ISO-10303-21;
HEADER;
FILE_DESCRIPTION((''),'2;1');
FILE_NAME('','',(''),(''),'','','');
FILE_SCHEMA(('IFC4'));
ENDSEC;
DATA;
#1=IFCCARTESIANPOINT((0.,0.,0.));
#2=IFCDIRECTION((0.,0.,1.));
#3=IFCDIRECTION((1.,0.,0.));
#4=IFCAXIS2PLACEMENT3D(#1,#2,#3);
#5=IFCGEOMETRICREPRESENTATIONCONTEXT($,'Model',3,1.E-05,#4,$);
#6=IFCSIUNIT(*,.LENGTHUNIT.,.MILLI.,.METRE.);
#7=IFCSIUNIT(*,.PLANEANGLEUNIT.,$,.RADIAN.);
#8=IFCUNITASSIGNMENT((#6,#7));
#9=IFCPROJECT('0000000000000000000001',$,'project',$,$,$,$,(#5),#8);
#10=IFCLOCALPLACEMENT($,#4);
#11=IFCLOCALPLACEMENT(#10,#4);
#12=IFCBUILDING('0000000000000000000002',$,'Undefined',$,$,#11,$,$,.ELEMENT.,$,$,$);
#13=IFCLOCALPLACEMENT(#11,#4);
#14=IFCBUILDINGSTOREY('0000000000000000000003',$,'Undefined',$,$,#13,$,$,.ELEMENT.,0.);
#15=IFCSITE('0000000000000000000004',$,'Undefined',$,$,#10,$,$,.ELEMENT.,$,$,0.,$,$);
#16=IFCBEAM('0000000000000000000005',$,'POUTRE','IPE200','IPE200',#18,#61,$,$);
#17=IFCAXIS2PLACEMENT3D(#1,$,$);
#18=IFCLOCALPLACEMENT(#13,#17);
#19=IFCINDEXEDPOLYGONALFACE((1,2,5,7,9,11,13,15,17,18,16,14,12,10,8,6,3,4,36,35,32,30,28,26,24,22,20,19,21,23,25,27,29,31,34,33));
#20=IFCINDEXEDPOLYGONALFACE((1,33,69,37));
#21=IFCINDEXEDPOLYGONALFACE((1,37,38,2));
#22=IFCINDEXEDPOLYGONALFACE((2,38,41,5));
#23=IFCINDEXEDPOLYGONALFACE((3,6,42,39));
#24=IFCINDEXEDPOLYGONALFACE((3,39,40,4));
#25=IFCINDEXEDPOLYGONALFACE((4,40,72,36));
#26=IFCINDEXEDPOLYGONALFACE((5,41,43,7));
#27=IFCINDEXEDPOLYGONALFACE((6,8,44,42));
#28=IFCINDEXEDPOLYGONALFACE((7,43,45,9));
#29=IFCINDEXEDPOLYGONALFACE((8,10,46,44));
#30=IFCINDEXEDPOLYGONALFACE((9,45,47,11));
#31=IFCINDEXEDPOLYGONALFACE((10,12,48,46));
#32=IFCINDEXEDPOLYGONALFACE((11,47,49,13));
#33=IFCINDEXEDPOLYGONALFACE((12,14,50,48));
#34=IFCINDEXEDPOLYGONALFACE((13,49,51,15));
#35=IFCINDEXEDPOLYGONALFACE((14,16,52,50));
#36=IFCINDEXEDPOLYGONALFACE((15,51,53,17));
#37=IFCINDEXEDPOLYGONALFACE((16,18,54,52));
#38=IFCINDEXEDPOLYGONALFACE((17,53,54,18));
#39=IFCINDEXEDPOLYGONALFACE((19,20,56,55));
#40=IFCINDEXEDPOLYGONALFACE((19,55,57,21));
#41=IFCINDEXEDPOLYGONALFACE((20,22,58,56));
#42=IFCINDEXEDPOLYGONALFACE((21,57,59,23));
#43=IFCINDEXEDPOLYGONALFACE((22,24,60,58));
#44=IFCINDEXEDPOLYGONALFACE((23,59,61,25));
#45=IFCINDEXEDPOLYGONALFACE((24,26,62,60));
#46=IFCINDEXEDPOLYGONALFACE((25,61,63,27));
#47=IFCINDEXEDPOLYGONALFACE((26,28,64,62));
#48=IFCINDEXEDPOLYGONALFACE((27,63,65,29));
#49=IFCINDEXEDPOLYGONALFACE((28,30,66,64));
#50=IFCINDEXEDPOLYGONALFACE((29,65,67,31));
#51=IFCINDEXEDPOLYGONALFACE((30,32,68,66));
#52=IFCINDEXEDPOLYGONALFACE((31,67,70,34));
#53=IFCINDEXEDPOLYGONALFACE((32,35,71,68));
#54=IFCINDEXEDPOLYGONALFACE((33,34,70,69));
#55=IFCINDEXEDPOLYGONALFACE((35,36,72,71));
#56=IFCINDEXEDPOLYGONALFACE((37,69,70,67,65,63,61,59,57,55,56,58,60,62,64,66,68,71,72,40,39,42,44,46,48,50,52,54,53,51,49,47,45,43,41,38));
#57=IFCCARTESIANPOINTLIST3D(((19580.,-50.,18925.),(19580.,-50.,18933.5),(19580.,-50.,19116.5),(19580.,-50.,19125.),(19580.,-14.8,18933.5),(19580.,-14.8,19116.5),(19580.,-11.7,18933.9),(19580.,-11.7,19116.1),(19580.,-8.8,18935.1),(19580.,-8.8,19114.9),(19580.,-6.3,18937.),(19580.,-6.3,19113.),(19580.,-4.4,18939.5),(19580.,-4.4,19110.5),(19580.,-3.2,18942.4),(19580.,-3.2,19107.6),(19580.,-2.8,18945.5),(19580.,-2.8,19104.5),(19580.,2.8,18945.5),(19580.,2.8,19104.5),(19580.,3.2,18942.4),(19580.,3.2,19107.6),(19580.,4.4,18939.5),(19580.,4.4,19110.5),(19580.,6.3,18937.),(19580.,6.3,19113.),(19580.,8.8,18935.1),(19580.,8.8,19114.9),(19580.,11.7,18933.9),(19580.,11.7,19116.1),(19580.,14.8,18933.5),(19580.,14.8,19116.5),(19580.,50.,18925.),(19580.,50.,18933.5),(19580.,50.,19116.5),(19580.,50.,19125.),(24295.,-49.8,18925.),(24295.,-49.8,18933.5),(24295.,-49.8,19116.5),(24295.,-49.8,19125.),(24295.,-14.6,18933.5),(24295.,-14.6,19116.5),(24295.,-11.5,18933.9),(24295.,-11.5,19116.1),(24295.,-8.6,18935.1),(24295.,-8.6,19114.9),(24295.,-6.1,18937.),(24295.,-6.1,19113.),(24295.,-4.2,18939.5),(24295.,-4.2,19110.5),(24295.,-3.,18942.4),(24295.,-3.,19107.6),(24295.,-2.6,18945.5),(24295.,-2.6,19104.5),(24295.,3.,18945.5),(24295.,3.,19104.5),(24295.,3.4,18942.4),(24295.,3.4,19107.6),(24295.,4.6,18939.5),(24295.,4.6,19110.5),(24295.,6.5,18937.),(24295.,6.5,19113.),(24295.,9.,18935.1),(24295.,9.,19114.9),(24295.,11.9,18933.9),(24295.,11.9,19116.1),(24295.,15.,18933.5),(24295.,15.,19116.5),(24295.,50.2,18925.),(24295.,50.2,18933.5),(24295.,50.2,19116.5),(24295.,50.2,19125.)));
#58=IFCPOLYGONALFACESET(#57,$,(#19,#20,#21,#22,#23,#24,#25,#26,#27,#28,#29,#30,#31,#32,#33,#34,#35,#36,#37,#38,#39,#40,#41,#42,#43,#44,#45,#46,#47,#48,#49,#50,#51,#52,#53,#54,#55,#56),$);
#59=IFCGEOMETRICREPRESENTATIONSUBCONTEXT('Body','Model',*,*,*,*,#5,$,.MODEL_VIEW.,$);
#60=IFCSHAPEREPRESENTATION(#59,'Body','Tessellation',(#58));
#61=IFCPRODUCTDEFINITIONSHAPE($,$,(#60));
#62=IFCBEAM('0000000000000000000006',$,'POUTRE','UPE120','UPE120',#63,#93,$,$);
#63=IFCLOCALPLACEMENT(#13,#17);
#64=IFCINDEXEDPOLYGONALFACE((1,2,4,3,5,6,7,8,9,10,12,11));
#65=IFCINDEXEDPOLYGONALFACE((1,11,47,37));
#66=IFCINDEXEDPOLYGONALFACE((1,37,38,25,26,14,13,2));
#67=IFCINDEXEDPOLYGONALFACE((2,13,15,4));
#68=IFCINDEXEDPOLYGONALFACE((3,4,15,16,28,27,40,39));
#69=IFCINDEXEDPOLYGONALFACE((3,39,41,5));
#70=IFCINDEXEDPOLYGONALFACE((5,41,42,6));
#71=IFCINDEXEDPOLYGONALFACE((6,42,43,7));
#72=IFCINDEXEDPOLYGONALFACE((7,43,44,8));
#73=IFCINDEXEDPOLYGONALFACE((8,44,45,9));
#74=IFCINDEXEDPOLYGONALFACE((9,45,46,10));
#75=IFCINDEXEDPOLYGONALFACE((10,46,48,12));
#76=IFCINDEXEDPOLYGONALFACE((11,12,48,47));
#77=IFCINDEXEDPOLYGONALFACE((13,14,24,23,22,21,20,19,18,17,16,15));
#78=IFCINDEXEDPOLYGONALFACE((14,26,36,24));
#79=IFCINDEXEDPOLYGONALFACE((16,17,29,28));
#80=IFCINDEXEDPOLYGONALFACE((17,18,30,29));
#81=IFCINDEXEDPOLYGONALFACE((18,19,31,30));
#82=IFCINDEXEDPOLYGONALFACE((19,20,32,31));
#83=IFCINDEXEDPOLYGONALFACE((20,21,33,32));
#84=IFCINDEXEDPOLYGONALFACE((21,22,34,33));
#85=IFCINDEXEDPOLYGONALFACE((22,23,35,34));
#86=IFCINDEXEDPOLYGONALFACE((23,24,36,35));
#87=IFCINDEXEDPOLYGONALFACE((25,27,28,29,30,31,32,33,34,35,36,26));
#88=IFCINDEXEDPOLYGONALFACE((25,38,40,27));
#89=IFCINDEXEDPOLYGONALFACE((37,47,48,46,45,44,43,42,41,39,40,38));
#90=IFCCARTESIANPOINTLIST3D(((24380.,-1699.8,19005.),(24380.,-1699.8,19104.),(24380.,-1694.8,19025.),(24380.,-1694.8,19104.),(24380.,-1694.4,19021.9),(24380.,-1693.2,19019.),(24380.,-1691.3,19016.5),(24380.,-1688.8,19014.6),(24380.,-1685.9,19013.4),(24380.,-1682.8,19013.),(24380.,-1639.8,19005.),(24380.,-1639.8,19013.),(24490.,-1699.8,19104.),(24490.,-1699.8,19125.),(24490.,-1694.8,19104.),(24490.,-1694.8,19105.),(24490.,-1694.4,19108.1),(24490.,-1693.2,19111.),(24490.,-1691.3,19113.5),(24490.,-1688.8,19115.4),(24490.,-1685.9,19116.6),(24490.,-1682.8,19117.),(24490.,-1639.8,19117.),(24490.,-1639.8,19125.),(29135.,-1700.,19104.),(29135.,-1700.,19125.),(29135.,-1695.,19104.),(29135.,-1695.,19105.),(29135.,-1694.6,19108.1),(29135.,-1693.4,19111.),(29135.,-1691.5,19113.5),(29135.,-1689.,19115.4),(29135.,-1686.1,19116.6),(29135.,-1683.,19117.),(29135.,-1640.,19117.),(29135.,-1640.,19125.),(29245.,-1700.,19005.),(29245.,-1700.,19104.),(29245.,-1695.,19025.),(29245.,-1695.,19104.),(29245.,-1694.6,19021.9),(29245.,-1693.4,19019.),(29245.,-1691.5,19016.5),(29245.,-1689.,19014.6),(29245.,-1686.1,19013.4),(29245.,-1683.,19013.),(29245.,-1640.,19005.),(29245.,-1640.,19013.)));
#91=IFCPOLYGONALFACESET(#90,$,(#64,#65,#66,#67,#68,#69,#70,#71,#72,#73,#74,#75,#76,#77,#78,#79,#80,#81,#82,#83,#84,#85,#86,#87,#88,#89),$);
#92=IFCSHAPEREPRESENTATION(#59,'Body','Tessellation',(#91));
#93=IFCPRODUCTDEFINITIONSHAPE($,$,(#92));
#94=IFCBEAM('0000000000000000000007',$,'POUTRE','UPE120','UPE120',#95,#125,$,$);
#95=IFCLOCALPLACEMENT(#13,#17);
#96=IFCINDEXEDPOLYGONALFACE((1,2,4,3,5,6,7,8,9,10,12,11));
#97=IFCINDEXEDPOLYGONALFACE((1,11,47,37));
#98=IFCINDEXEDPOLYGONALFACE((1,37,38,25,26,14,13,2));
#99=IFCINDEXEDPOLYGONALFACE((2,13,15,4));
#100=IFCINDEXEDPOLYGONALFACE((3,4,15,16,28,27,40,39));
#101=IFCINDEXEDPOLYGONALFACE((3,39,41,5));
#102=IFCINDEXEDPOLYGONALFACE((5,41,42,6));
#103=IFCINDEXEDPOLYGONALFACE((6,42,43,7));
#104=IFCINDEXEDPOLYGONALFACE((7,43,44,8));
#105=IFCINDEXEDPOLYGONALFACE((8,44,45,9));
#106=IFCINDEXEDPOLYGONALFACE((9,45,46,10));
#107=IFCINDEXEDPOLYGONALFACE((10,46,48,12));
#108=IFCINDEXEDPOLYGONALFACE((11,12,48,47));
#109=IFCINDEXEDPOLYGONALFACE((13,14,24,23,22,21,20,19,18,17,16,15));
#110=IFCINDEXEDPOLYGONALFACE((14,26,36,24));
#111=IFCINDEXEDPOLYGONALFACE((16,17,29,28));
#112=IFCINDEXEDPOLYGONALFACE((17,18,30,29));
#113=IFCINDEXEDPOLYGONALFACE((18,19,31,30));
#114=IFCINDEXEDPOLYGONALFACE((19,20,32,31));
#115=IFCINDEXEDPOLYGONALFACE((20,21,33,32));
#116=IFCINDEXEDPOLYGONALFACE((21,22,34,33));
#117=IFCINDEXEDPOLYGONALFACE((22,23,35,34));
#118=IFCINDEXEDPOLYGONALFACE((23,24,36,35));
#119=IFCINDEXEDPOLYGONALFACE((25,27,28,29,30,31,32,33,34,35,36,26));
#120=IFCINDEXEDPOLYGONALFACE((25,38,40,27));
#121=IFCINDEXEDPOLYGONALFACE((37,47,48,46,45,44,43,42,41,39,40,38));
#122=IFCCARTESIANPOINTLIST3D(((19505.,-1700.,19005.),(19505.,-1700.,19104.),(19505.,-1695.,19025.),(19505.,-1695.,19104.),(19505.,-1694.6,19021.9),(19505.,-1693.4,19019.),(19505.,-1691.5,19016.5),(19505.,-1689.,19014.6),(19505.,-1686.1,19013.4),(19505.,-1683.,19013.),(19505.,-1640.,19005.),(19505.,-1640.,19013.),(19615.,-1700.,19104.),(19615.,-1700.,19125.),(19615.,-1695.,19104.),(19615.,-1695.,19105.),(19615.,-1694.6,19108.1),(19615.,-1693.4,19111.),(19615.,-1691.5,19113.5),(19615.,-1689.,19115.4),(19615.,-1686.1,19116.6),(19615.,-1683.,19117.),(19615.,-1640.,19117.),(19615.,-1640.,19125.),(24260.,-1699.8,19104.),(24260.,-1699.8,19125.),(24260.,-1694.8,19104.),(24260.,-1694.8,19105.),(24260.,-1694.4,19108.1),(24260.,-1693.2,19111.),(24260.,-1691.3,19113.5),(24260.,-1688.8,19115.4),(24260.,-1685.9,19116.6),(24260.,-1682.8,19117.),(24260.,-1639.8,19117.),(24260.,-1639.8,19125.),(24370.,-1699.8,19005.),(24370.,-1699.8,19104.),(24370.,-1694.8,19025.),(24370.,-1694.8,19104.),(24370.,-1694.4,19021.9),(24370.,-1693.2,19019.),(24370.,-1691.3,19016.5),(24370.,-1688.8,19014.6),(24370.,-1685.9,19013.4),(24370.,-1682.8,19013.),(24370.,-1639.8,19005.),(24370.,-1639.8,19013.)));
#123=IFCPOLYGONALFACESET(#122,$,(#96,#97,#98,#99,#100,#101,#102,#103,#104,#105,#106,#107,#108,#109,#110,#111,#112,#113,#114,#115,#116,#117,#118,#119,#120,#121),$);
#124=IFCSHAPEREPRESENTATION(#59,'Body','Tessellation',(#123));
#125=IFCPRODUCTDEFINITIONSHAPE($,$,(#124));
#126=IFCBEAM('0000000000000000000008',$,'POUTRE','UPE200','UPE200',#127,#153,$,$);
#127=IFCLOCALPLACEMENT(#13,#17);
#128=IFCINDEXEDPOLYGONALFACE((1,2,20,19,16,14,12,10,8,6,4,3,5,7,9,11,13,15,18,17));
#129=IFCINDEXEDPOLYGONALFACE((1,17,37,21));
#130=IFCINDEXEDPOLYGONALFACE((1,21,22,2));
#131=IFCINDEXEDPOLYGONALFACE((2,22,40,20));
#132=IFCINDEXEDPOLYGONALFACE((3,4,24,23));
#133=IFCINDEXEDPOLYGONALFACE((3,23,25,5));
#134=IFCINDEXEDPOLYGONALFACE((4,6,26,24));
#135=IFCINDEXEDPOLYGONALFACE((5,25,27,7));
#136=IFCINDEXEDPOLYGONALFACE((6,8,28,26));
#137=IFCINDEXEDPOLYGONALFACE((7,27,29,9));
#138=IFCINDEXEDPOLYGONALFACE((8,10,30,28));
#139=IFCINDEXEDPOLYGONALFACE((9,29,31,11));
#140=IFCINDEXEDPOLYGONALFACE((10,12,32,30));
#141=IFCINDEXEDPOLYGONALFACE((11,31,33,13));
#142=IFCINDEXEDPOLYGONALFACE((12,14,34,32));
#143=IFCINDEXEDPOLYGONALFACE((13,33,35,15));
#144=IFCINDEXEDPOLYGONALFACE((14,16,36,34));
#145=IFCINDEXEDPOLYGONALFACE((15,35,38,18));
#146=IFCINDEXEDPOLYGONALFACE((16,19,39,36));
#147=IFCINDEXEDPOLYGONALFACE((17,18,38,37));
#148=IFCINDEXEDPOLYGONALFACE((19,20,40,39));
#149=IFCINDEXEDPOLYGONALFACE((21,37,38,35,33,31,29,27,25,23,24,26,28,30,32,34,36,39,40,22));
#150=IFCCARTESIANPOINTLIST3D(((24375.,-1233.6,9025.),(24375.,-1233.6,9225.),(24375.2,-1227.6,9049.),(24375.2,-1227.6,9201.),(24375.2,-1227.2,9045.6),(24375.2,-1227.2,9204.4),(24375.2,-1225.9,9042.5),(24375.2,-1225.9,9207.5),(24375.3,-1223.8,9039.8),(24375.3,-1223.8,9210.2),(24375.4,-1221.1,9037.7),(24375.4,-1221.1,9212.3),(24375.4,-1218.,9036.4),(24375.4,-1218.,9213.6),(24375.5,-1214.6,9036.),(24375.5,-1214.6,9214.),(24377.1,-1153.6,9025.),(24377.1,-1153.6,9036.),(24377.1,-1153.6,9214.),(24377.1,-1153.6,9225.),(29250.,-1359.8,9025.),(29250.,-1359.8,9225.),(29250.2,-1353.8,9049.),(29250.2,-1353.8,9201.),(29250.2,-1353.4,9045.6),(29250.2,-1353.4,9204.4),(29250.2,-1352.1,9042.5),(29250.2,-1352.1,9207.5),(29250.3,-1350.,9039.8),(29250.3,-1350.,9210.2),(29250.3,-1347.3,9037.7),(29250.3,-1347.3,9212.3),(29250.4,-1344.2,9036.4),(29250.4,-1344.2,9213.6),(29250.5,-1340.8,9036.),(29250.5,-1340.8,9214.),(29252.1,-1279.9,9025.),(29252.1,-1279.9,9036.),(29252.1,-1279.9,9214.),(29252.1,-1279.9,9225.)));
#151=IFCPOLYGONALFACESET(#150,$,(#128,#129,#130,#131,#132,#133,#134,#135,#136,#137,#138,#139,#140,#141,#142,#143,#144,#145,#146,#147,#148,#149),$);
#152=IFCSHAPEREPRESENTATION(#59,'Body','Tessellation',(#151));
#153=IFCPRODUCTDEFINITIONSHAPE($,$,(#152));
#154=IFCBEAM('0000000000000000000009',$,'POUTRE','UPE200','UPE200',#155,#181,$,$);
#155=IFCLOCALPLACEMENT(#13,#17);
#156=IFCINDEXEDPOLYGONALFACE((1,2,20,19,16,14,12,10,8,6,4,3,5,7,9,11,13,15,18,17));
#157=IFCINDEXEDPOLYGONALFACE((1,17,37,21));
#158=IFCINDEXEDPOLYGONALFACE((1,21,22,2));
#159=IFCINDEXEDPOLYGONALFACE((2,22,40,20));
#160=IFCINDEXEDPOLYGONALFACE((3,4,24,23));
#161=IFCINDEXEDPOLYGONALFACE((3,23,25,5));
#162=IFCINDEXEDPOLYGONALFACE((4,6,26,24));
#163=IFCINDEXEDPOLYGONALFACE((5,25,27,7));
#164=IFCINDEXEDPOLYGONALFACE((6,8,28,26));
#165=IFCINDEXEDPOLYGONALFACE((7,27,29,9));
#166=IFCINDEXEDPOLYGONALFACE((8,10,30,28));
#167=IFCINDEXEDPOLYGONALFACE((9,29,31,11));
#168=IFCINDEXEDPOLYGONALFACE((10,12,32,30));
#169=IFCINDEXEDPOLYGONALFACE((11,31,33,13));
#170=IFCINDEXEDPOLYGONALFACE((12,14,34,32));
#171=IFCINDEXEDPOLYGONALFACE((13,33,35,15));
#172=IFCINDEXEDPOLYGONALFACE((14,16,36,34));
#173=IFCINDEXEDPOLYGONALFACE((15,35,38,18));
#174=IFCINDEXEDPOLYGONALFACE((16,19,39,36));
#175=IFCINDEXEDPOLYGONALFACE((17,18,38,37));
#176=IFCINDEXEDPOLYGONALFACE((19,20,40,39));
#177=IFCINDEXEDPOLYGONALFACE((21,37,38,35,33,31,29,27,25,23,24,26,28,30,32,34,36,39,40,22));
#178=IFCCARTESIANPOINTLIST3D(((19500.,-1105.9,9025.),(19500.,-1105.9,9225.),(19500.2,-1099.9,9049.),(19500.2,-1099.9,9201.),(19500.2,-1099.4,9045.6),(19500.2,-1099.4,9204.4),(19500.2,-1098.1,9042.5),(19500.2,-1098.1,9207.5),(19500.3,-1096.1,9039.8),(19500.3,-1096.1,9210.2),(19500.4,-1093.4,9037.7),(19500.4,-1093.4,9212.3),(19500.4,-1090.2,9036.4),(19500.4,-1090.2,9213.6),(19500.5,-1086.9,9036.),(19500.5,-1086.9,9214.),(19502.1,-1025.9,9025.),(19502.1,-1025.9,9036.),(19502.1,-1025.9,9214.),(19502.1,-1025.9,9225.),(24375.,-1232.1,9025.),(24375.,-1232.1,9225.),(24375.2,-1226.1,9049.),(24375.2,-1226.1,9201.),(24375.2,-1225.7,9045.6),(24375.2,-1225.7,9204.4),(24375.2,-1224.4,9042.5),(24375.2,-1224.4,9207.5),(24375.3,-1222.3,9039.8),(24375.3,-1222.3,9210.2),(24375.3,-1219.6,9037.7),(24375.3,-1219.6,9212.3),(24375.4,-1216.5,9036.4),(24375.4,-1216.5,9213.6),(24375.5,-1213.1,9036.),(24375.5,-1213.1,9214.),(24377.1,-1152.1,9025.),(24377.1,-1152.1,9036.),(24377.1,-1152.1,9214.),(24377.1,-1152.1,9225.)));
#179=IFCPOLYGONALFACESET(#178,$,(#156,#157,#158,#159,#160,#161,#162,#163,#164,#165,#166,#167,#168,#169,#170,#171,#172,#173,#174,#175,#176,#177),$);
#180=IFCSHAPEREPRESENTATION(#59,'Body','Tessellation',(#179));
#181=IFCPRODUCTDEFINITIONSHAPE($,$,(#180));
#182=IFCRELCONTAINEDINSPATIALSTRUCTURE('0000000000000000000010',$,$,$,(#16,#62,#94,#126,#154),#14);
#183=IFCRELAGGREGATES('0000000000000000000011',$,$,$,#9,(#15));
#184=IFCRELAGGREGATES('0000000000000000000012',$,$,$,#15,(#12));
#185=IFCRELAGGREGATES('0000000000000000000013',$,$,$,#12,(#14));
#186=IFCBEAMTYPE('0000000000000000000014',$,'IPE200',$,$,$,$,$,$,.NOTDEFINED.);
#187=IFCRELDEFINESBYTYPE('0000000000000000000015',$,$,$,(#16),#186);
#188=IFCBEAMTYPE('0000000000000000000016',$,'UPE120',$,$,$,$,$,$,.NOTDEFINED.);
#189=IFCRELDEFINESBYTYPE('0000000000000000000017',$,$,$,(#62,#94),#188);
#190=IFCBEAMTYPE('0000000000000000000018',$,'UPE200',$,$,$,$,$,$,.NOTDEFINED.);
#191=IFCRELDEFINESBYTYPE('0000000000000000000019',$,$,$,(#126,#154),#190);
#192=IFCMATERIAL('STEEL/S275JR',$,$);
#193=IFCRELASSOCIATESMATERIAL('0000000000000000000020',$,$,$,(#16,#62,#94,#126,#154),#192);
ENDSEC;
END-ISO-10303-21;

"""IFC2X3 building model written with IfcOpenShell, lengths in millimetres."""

from ifc_helpers import new_model, si_unit, frame, origin_with_axes, origin_2d_with_axis, place, context, subcontext, project, spatial, rectangle, i_section, u_section, extrude, boolean, material, type_object, element, save


model = new_model("IFC2X3")

# Units and contexts
model_context = context("Model", 3, precision=1e-05, world=origin_with_axes())
body_context = subcontext(model_context, "Body", "Model", "MODEL_VIEW")
ifc_project = project(units=[si_unit("LENGTHUNIT", "METRE", prefix="MILLI"), si_unit("PLANEANGLEUNIT", "RADIAN")], contexts=[model_context])

# Site, building, storey
site_placement = place(None, origin_with_axes())
site = spatial("IfcSite", under=ifc_project, at=site_placement, Name="Undefined", CompositionType="ELEMENT", RefElevation=0.0)
building_placement = place(site_placement, origin_with_axes())
building = spatial("IfcBuilding", under=site, at=building_placement, Name="Undefined", CompositionType="ELEMENT")
storey_placement = place(building_placement, origin_with_axes())
storey = spatial("IfcBuildingStorey", under=building, at=storey_placement, Name="Undefined", CompositionType="ELEMENT", Elevation=0.0)

# Shared definitions
ifc_material_1 = material(Name="STEEL/S275JR")

# Beams
beam_type_1 = type_object("IfcBeamType", Name="IPE200", PredefinedType="NOTDEFINED")
beam_1_placement = place(storey_placement, frame((19500.0, 0.0, 19025.0), z_axis=(-0.000006, 0.0, 1.0), x_axis=(1.0, 0.000043, 0.000006)))
element("IfcBeam", 1, at=beam_1_placement, inside=storey, type_object=beam_type_1, material=ifc_material_1, Name="POUTRE", Description="IPE200", ObjectType="IPE200", context=body_context, shape_type="SweptSolid", body=[
    extrude(i_section(OverallWidth=100.0, OverallDepth=200.0, WebThickness=5.6, FlangeThickness=8.5, FilletRadius=12.0, at=origin_2d_with_axis()), frame((4795.0, 0.0, 0.0), z_axis=(-1.0, 0.0, 0.0), x_axis=(0.0, -1.0, 0.0)), (0.0, 0.0, 1.0), 4715.0),
])
beam_type_2 = type_object("IfcBeamType", Name="UPE120", PredefinedType="NOTDEFINED")
beam_2_placement = place(storey_placement, frame((24382.5, -1669.8, 19065.0), z_axis=(0.0, 0.0, -1.0), x_axis=(1.0, -0.000043, 0.0)))
element("IfcBeam", 2, at=beam_2_placement, inside=storey, type_object=beam_type_2, material=ifc_material_1, Name="POUTRE", Description="UPE120", ObjectType="UPE120", context=body_context, shape_type="CSG", body=[
    boolean("DIFFERENCE", boolean("DIFFERENCE", extrude(u_section(Depth=120.0, FlangeWidth=60.0, WebThickness=5.0, FlangeThickness=8.0, FilletRadius=12.0, at=origin_2d_with_axis()), frame((4862.5, 0.0, 0.0), z_axis=(-1.0, 0.0, 0.0), x_axis=(0.0, -1.0, 0.0)), (0.0, 0.0, 1.0), 4865.0), extrude(rectangle(XDim=22.0, YDim=112.0, at=origin_2d_with_axis()), frame((4808.5, -31.2, -50.0), z_axis=(0.000043, 1.0, 0.0), x_axis=(0.0, 0.0, 1.0)), (0.0, 0.0, 1.0), 62.2)), extrude(rectangle(XDim=22.0, YDim=112.0, at=origin_2d_with_axis()), frame((51.5, 31.2, -50.0), z_axis=(-0.000043, -1.0, 0.0), x_axis=(0.0, 0.0, 1.0)), (0.0, 0.0, 1.0), 62.2)),
])
beam_3_placement = place(storey_placement, frame((19500.0, -1670.0, 19065.0), z_axis=(0.0, 0.0, -1.0), x_axis=(1.0, 0.000043, 0.0)))
element("IfcBeam", 3, at=beam_3_placement, inside=storey, type_object=beam_type_2, material=ifc_material_1, Name="POUTRE", Description="UPE120", ObjectType="UPE120", context=body_context, shape_type="CSG", body=[
    boolean("DIFFERENCE", boolean("DIFFERENCE", extrude(u_section(Depth=120.0, FlangeWidth=60.0, WebThickness=5.0, FlangeThickness=8.0, FilletRadius=12.0, at=origin_2d_with_axis()), frame((4870.0, 0.0, 0.0), z_axis=(-1.0, 0.0, 0.0), x_axis=(0.0, -1.0, 0.0)), (0.0, 0.0, 1.0), 4865.0), extrude(rectangle(XDim=22.0, YDim=112.0, at=origin_2d_with_axis()), frame((4816.0, -31.0, -50.0), z_axis=(-0.000043, 1.0, 0.0), x_axis=(0.0, 0.0, 1.0)), (0.0, 0.0, 1.0), 62.2)), extrude(rectangle(XDim=22.0, YDim=112.0, at=origin_2d_with_axis()), frame((59.0, 31.0, -50.0), z_axis=(0.000043, -1.0, 0.0), x_axis=(0.0, 0.0, 1.0)), (0.0, 0.0, 1.0), 62.2)),
])
beam_type_3 = type_object("IfcBeamType", Name="UPE200", PredefinedType="NOTDEFINED")
for number, where, z_axis, x_axis, name in (
    (4, (24376.0, -1193.6, 9125.0), (0.0, 0.0, -1.0), (0.999665, -0.025886, 0.0), "POUTRE"),
    (5, (19501.0, -1065.9, 9125.0), (0.0, 0.0, -1.0), (0.999665, -0.025886, 0.0), "POUTRE"),
):
    element("IfcBeam", number, at=place(storey_placement, frame(where, z_axis=z_axis, x_axis=x_axis)), inside=storey, type_object=beam_type_3, material=ifc_material_1, Name=name, Description="UPE200", ObjectType="UPE200", context=body_context, shape_type="SweptSolid", body=[
        extrude(u_section(Depth=200.0, FlangeWidth=80.0, WebThickness=6.0, FlangeThickness=11.0, FilletRadius=13.0, at=origin_2d_with_axis()), frame((4876.6, 0.0, 0.0), z_axis=(-1.0, 0.0, 0.0), x_axis=(0.0, -1.0, 0.0)), (0.0, 0.0, 1.0), 4876.6),
    ])

save(model, "model.ifc")
